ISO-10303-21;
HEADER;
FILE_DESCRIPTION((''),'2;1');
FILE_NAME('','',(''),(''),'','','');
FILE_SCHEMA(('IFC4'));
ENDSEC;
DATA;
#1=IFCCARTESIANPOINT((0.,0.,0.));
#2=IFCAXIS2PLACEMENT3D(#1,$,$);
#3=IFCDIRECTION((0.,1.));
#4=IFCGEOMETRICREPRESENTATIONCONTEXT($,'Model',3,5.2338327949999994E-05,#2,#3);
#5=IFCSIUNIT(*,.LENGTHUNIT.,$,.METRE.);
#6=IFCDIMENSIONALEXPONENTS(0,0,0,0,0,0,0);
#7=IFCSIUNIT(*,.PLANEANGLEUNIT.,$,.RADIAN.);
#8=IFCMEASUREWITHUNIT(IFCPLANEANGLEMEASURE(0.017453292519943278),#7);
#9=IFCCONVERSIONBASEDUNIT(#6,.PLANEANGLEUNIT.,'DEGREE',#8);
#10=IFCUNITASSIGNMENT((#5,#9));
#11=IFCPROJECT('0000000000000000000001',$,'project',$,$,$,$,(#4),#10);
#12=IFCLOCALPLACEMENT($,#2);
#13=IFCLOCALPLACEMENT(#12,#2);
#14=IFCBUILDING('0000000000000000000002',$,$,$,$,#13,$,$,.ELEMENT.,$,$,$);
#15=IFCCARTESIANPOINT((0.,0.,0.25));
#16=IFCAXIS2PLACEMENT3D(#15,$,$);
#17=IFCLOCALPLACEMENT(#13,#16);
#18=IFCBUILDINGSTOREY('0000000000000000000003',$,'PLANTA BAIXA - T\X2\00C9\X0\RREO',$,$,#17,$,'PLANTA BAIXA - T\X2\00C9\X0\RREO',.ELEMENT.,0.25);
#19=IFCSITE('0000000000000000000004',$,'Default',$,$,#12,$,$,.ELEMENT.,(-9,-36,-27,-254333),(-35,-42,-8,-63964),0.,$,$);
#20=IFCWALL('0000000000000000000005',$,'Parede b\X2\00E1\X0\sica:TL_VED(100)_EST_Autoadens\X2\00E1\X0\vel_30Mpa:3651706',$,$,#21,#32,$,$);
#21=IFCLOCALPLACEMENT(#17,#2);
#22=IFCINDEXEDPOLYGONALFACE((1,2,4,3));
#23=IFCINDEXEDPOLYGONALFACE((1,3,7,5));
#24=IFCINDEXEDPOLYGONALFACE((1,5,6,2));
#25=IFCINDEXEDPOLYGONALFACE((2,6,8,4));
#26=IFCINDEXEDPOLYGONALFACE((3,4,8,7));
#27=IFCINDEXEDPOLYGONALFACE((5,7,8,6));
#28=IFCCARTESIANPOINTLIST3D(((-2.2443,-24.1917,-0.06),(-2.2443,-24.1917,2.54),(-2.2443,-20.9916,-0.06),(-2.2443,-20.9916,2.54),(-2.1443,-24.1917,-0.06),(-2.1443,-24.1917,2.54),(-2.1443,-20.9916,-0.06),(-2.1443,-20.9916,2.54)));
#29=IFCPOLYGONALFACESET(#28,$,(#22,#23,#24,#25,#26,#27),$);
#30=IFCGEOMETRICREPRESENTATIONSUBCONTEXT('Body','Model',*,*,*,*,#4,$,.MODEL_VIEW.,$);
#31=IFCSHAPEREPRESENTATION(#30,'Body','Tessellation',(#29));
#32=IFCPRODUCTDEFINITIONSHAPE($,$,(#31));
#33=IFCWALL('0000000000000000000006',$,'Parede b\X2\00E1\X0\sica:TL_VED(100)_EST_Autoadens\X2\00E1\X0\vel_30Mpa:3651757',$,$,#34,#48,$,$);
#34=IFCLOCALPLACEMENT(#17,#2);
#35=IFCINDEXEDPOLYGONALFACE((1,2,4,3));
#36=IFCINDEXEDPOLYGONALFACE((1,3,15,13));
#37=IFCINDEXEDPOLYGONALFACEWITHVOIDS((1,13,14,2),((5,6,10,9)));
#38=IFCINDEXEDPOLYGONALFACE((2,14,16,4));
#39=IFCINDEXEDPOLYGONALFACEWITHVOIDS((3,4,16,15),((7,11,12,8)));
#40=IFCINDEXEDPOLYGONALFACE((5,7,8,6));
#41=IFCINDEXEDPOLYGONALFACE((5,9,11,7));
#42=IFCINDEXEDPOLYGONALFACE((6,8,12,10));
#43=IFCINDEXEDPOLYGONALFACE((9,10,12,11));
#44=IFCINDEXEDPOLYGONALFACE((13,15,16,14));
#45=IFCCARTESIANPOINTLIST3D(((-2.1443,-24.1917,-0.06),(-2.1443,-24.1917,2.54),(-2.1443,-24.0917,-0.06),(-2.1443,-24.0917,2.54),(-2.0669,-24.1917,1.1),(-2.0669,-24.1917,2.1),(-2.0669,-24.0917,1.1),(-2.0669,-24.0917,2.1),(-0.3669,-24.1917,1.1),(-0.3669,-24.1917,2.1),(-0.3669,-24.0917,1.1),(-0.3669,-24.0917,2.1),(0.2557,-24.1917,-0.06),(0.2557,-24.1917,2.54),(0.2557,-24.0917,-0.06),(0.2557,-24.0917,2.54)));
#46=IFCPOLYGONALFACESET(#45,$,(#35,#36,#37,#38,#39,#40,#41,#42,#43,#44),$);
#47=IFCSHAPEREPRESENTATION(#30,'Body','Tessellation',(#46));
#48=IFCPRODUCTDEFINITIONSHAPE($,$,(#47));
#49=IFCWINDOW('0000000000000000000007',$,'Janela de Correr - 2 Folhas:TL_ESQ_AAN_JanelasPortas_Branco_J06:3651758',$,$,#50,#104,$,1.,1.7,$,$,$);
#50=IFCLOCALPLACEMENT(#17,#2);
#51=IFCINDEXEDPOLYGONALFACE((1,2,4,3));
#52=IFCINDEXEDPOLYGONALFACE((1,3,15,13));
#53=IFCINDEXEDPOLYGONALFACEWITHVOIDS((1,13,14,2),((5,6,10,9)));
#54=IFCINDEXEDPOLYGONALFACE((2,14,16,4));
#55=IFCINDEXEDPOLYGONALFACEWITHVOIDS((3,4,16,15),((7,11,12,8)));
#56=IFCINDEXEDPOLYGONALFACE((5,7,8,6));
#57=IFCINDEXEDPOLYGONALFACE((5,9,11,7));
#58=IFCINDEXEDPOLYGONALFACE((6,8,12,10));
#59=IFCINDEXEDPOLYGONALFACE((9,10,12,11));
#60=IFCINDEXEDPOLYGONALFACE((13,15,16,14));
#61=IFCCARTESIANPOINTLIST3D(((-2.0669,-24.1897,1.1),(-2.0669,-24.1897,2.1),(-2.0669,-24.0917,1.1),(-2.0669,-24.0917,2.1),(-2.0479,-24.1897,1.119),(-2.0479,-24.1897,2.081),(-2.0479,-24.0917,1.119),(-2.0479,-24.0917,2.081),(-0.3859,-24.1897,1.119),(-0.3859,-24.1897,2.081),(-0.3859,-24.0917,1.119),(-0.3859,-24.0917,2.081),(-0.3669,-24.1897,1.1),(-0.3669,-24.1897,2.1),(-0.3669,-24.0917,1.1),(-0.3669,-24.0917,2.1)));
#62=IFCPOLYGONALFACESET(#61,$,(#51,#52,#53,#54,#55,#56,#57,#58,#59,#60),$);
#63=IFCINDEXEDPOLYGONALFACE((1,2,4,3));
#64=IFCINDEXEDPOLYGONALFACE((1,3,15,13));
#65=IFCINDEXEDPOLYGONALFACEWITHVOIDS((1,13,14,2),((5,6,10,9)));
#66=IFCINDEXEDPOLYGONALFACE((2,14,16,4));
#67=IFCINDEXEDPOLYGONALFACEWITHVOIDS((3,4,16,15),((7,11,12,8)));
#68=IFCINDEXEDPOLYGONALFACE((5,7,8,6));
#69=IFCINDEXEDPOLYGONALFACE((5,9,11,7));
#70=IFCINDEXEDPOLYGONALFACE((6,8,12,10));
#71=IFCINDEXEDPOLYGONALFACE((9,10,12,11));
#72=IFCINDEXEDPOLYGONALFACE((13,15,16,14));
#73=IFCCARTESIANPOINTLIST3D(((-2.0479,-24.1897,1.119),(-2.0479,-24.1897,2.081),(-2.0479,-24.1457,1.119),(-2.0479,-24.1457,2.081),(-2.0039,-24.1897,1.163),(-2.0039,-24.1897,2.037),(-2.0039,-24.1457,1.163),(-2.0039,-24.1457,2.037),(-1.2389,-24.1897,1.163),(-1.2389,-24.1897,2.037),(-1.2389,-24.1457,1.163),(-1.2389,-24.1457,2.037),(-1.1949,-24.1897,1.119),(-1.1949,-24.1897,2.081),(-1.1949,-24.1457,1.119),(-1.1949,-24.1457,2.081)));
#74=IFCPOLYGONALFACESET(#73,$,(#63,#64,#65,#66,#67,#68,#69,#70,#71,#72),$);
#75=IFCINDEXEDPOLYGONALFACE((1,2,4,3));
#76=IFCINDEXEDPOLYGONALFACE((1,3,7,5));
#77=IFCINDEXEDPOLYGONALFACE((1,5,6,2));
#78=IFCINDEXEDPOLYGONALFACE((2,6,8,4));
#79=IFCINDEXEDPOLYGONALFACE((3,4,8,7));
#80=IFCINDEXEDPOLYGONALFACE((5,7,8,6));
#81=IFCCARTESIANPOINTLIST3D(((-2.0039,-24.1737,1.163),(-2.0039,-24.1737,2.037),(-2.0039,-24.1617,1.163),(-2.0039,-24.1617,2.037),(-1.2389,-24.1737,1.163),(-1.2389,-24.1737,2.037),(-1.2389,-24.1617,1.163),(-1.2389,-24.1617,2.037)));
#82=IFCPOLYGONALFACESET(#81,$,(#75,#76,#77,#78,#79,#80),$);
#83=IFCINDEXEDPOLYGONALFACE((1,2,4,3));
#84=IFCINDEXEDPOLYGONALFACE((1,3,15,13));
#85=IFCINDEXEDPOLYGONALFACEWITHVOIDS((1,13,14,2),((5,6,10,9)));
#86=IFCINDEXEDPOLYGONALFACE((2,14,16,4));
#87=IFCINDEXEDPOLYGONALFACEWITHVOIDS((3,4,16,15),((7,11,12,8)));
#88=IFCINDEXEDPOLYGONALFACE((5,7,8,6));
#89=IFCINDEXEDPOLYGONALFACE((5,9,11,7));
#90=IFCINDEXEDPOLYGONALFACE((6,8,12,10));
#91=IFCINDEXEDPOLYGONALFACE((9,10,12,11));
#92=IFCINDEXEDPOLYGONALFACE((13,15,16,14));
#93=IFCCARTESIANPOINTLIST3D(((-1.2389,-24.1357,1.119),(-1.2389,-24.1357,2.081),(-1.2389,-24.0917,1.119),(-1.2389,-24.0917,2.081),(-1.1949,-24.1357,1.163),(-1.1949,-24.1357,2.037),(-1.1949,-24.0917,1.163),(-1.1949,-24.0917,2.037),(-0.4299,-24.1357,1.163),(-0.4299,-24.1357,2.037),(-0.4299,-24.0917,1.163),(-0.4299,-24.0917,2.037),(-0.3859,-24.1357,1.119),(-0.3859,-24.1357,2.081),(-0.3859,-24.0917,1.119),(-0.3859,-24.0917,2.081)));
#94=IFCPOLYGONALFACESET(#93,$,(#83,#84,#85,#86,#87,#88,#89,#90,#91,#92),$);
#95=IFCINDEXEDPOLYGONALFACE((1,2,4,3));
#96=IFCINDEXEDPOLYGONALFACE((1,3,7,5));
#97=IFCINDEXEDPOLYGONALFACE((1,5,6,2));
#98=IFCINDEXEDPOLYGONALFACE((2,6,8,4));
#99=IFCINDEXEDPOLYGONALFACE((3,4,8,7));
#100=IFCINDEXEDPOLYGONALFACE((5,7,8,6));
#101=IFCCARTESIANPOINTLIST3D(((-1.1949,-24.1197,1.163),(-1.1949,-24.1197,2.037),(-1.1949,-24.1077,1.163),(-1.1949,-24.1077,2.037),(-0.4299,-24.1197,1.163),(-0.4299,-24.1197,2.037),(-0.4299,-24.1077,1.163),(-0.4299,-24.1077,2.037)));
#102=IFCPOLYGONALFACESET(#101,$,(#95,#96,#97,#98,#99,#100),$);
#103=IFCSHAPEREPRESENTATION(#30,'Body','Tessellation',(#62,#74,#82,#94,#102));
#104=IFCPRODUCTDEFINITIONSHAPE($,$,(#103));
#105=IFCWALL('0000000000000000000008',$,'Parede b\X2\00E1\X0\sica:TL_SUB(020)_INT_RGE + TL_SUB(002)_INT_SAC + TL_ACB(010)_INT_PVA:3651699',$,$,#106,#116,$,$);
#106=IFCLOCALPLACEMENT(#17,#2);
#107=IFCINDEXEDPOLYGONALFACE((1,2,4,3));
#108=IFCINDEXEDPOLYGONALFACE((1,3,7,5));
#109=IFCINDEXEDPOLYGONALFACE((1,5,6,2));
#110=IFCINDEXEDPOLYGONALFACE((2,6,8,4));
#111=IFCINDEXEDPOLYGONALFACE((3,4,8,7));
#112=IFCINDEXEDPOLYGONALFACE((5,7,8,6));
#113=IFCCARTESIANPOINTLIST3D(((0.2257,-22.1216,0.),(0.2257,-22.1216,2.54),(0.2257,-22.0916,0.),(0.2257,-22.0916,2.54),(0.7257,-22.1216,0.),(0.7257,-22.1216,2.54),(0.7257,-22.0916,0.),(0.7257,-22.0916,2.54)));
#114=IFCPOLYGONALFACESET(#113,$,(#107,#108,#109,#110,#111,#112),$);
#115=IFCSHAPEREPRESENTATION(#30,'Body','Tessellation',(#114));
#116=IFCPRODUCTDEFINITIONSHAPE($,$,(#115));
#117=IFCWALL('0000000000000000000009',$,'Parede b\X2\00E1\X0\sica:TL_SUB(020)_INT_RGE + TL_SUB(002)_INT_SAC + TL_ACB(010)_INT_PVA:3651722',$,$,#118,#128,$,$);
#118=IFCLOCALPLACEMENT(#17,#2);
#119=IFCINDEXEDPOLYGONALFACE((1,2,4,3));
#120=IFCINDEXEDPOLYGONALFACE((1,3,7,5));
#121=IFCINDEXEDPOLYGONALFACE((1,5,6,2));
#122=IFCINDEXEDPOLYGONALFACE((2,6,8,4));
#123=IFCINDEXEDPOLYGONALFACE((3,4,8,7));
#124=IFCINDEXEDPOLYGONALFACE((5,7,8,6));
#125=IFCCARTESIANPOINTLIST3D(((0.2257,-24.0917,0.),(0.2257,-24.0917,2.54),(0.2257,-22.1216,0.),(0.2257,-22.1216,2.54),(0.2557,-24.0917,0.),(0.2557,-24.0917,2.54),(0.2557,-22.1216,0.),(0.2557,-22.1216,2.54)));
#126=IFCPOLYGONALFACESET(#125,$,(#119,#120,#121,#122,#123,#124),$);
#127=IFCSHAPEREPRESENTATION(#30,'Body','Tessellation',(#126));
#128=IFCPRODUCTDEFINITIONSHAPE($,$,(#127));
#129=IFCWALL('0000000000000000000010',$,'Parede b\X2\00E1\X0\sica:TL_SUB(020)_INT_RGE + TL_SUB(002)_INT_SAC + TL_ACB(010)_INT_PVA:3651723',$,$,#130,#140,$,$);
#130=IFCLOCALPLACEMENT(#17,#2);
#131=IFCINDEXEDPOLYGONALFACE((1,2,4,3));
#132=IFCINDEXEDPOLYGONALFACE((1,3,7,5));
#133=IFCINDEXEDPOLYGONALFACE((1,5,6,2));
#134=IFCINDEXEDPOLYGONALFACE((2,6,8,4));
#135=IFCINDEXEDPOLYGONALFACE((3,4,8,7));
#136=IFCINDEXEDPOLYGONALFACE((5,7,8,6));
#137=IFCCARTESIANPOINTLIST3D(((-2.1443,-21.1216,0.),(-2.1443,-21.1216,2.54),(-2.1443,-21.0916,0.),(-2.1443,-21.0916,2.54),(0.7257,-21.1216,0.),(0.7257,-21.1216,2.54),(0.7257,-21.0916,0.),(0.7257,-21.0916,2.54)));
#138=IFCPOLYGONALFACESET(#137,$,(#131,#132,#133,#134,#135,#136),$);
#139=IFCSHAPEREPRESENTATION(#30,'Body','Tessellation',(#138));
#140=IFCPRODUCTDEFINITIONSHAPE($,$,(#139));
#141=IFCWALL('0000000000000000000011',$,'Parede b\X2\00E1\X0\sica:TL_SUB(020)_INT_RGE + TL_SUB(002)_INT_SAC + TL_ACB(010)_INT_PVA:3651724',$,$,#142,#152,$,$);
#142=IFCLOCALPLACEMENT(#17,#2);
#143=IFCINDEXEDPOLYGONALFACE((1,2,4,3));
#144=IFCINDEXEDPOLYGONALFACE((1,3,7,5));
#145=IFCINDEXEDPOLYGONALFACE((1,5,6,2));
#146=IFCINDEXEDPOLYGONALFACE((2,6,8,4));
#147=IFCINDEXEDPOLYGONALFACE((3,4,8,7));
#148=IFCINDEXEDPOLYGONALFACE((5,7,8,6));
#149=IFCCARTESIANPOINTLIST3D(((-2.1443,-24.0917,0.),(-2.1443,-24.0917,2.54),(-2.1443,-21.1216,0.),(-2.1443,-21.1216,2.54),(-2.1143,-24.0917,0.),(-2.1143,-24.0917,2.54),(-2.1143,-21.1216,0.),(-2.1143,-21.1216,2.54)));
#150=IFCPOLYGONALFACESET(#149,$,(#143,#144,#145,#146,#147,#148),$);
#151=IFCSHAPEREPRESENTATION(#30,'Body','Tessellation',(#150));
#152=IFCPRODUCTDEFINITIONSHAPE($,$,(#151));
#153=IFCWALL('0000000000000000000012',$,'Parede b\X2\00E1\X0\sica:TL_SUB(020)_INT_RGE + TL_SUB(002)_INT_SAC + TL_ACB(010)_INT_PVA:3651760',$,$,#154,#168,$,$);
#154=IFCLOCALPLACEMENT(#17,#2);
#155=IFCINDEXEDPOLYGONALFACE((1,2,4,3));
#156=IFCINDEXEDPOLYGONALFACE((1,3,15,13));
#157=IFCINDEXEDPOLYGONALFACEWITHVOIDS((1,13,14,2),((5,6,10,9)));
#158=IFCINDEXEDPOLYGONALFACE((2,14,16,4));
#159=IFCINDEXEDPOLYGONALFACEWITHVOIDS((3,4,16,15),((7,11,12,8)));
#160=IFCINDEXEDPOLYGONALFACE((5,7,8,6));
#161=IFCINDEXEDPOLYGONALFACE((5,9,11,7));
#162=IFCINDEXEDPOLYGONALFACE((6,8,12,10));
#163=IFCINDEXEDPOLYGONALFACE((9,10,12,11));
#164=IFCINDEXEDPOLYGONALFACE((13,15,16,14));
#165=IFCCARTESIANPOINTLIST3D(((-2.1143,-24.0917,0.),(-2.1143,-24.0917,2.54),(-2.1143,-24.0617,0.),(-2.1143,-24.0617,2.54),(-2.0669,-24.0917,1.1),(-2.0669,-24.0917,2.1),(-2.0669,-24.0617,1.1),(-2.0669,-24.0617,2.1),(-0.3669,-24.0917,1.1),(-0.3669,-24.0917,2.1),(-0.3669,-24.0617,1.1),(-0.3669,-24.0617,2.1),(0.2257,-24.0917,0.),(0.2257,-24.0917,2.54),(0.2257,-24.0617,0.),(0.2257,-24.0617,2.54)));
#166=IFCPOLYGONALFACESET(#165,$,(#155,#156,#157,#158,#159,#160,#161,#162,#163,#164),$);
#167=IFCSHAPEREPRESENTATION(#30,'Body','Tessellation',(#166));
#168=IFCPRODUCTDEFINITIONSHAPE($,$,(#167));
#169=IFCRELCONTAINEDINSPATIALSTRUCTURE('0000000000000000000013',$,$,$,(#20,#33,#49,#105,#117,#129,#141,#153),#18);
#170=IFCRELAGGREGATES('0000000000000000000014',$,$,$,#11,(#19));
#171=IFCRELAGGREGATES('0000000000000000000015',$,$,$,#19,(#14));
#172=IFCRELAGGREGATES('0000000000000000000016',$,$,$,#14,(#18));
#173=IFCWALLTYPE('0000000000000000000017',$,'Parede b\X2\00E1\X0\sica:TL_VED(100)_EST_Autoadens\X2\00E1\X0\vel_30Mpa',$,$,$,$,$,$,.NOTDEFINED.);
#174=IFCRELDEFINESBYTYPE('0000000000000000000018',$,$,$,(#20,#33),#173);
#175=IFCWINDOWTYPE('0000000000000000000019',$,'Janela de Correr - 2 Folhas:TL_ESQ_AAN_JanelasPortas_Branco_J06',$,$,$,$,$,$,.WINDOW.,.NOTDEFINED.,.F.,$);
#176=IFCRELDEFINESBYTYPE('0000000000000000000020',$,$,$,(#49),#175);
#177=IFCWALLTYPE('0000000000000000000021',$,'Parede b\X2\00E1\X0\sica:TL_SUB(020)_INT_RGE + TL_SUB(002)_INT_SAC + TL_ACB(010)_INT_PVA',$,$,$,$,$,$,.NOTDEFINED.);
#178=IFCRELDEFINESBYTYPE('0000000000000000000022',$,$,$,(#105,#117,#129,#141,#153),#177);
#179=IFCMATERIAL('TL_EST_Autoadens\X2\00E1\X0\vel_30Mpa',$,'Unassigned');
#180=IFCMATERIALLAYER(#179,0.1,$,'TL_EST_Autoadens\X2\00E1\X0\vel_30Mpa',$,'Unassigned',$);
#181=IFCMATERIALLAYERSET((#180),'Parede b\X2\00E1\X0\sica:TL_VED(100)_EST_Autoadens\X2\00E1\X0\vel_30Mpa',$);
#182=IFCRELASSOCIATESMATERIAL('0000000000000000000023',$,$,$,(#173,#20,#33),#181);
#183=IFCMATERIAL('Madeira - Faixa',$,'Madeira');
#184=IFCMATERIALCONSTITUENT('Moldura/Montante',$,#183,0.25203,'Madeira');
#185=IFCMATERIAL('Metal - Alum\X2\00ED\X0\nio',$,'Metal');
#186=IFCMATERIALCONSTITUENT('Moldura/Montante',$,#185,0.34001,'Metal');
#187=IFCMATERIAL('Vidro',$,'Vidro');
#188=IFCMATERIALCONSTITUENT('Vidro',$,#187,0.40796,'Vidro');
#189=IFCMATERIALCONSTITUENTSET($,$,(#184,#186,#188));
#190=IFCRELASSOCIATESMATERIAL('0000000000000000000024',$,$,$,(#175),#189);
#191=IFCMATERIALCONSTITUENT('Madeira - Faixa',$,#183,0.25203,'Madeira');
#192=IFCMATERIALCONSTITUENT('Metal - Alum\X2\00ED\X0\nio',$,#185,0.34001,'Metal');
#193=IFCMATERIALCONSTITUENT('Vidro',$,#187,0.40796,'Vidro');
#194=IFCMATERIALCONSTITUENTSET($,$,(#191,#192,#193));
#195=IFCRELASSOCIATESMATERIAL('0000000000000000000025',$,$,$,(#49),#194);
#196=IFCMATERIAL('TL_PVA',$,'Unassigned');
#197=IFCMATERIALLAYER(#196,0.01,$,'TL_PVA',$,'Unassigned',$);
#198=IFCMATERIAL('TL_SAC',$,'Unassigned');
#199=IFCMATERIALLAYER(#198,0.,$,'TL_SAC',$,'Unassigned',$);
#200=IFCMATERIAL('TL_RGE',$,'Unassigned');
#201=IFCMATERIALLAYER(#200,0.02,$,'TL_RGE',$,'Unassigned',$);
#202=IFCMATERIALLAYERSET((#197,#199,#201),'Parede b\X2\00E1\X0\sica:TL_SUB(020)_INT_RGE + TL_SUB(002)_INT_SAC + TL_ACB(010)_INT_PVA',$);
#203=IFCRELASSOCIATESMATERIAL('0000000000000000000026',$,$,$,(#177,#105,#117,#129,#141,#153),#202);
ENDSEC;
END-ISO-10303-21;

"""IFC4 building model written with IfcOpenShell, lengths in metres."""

from ifc_helpers import new_model, entity, si_unit, converted_unit, direction, frame, frame_2d, origin, origin_2d_with_axis, place, context, subcontext, project, spatial, polyline, rectangle, outline, extrude, source, transform, mapped, material, layer, layer_set, layer_usage, constituent, constituent_set, type_object, type_shapes, element, fill, save


model = new_model("IFC4")

# Units and contexts
model_context = context("Model", 3, precision=5.2338327949999994e-05, world=origin(), true_north=direction((0.0, 1.0)))
body_context = subcontext(model_context, "Body", "Model", "MODEL_VIEW")
ifc_project = project(units=[si_unit("LENGTHUNIT", "METRE"), converted_unit("PLANEANGLEUNIT", "DEGREE", entity("IfcPlaneAngleMeasure", 0.017453292519943278), si_unit("PLANEANGLEUNIT", "RADIAN"), dimensions=[0, 0, 0, 0, 0, 0, 0])], contexts=[model_context])

# Site, building, storey
site_placement = place(None, frame((0.0, 0.0, 0.0)))
site = spatial("IfcSite", under=ifc_project, at=site_placement, Name="Default", CompositionType="ELEMENT", RefLatitude=(-9, -36, -27, -254333), RefLongitude=(-35, -42, -8, -63964), RefElevation=0.0)
building_placement = place(site_placement, origin())
building = spatial("IfcBuilding", under=site, at=building_placement, CompositionType="ELEMENT")
storey_placement = place(building_placement, frame((0.0, 0.0, 0.25)))
storey = spatial("IfcBuildingStorey", under=building, at=storey_placement, Name="PLANTA BAIXA - TÉRREO", LongName="PLANTA BAIXA - TÉRREO", CompositionType="ELEMENT", Elevation=0.25)

# Wall
ifc_material_1 = material(Name="TL_EST_Autoadensável_30Mpa", Category="Unassigned")
ifc_layer_1 = layer(ifc_material_1, 0.1, Name="TL_EST_Autoadensável_30Mpa", Category="Unassigned")
ifc_layer_set_1 = layer_set([ifc_layer_1], Name="Parede básica:TL_VED(100)_EST_Autoadensável_30Mpa")
ifc_layer_usage_1 = layer_usage(ifc_layer_set_1, "AXIS2", "POSITIVE", -0.05)
wall_type_1 = type_object("IfcWallType", Name="Parede básica:TL_VED(100)_EST_Autoadensável_30Mpa", PredefinedType="NOTDEFINED", material=ifc_layer_set_1)
wall_1_placement = place(storey_placement, frame((-2.1943, -24.1917, -0.06), z_axis=(0.0, 0.0, 1.0), x_axis=(0.0, 1.0, 0.0)))
element("IfcWall", 1, at=wall_1_placement, inside=storey, type_object=wall_type_1, material=ifc_layer_usage_1, Name="Parede básica:TL_VED(100)_EST_Autoadensável_30Mpa:3651706", context=body_context, shape_type="SweptSolid", body=[
    extrude(rectangle(XDim=3.2001, YDim=0.1, at=frame_2d((1.6001, 0.0), x_axis=(-1.0, 0.0))), origin(), (0.0, 0.0, 1.0), 2.6),
])

# Wall, opening, window
ifc_layer_usage_2 = layer_usage(ifc_layer_set_1, "AXIS2", "POSITIVE", -0.05)
wall_2_placement = place(storey_placement, frame((-2.1443, -24.1417, -0.06)))
wall_2 = element("IfcWall", 2, at=wall_2_placement, inside=storey, type_object=wall_type_1, material=ifc_layer_usage_2, Name="Parede básica:TL_VED(100)_EST_Autoadensável_30Mpa:3651757", context=body_context, shape_type="SweptSolid", body=[
    extrude(rectangle(XDim=2.4, YDim=0.1, at=frame_2d((1.2, 0.0), x_axis=(-1.0, 0.0))), origin(), (0.0, 0.0, 1.0), 2.6),
])
opening_1_placement = place(wall_2_placement, frame((1.7774, 0.05, 1.16)))
opening_1 = element("IfcOpeningElement", 3, at=opening_1_placement, cuts=wall_2, PredefinedType="OPENING", context=body_context, shape_type="SweptSolid", body=[
    extrude(rectangle(XDim=1.0, YDim=1.7, at=frame_2d((0.5, 0.85), x_axis=(-1.0, 0.0))), frame((0.0, 0.0, 0.0), z_axis=(0.0, -1.0, 0.0), x_axis=(0.0, 0.0, 1.0)), (0.0, 0.0, 1.0), 0.1),
])
ifc_material_2 = material(Name="Madeira - Faixa", Category="Madeira")
ifc_constituent_1 = constituent(ifc_material_2, Name="Madeira - Faixa", Category="Madeira", fraction=0.25203)
ifc_material_3 = material(Name="Metal - Alumínio", Category="Metal")
ifc_constituent_2 = constituent(ifc_material_3, Name="Metal - Alumínio", Category="Metal", fraction=0.34001)
ifc_material_4 = material(Name="Vidro", Category="Vidro")
ifc_constituent_3 = constituent(ifc_material_4, Name="Vidro", Category="Vidro", fraction=0.40796)
ifc_constituent_set_1 = constituent_set(constituents=[ifc_constituent_1, ifc_constituent_2, ifc_constituent_3])
ifc_constituent_4 = constituent(ifc_material_2, Name="Moldura/Montante", Category="Madeira", fraction=0.25203)
ifc_constituent_5 = constituent(ifc_material_3, Name="Moldura/Montante", Category="Metal", fraction=0.34001)
ifc_constituent_6 = constituent(ifc_material_4, Name="Vidro", Category="Vidro", fraction=0.40796)
ifc_constituent_set_2 = constituent_set(constituents=[ifc_constituent_4, ifc_constituent_5, ifc_constituent_6])
window_type = type_object("IfcWindowType", Name="Janela de Correr - 2 Folhas:TL_ESQ_AAN_JanelasPortas_Branco_J06", ParameterTakesPrecedence=False, PartitioningType="NOTDEFINED", PredefinedType="WINDOW", material=ifc_constituent_set_2)
shared_shape_1 = source(origin(), body_context, "Body", "SweptSolid", [
    extrude(outline(polyline([(-0.85, -0.5), (0.85, -0.5), (0.85, 0.5), (-0.85, 0.5), (-0.85, -0.5)]), holes=[polyline([(-0.831, -0.481), (-0.831, 0.481), (0.831, 0.481), (0.831, -0.481), (-0.831, -0.481)])]), frame((0.85, 0.0, 0.5), z_axis=(0.0, 1.0, 0.0), x_axis=(1.0, 0.0, 0.0)), (0.0, 0.0, 1.0), 0.098),
    extrude(outline(polyline([(-0.4265, -0.481), (0.4265, -0.481), (0.4265, 0.481), (-0.4265, 0.481), (-0.4265, -0.481)]), holes=[polyline([(-0.3825, -0.437), (-0.3825, 0.437), (0.3825, 0.437), (0.3825, -0.437), (-0.3825, -0.437)])]), frame((1.2545, 0.054, 0.5), z_axis=(0.0, 1.0, 0.0), x_axis=(1.0, 0.0, 0.0)), (0.0, 0.0, 1.0), 0.044),
    extrude(rectangle(XDim=0.012, YDim=0.765, at=origin_2d_with_axis()), frame((1.2545, 0.076, 0.063), z_axis=(0.0, 0.0, 1.0), x_axis=(0.0, -1.0, 0.0)), (0.0, 0.0, 1.0), 0.874),
    extrude(outline(polyline([(-0.481, -0.4265), (0.481, -0.4265), (0.481, 0.4265), (-0.481, 0.4265), (-0.481, -0.4265)]), holes=[polyline([(-0.437, -0.3825), (-0.437, 0.3825), (0.437, 0.3825), (0.437, -0.3825), (-0.437, -0.3825)])]), frame((0.4455, 0.0, 0.5), z_axis=(0.0, 1.0, 0.0), x_axis=(0.0, 0.0, -1.0)), (0.0, 0.0, 1.0), 0.044),
    extrude(rectangle(XDim=0.012, YDim=0.765, at=origin_2d_with_axis()), frame((0.4455, 0.022, 0.063), z_axis=(0.0, 0.0, 1.0), x_axis=(0.0, -1.0, 0.0)), (0.0, 0.0, 1.0), 0.874),
])
type_shapes(window_type, [shared_shape_1])
window_placement = place(opening_1_placement, frame((0.0, 0.0, 0.0), z_axis=(0.0, 0.0, 1.0), x_axis=(-1.0, 0.0, 0.0)))
window = element("IfcWindow", 4, at=window_placement, inside=storey, type_object=window_type, material=ifc_constituent_set_1, Name="Janela de Correr - 2 Folhas:TL_ESQ_AAN_JanelasPortas_Branco_J06:3651758", OverallHeight=1.0, OverallWidth=1.7, context=body_context, shape_type="MappedRepresentation", body=[
    mapped(shared_shape_1, transform((0.0, 0.0, 0.0), scale=1.0)),
])
fill(opening_1, window)

# Walls
ifc_material_5 = material(Name="TL_PVA", Category="Unassigned")
ifc_layer_2 = layer(ifc_material_5, 0.01, Name="TL_PVA", Category="Unassigned")
ifc_material_6 = material(Name="TL_SAC", Category="Unassigned")
ifc_layer_3 = layer(ifc_material_6, 0.0, Name="TL_SAC", Category="Unassigned")
ifc_material_7 = material(Name="TL_RGE", Category="Unassigned")
ifc_layer_4 = layer(ifc_material_7, 0.02, Name="TL_RGE", Category="Unassigned")
ifc_layer_set_2 = layer_set([ifc_layer_2, ifc_layer_3, ifc_layer_4], Name="Parede básica:TL_SUB(020)_INT_RGE + TL_SUB(002)_INT_SAC + TL_ACB(010)_INT_PVA")
ifc_layer_usage_3 = layer_usage(ifc_layer_set_2, "AXIS2", "NEGATIVE", 0.015)
wall_type_2 = type_object("IfcWallType", Name="Parede básica:TL_SUB(020)_INT_RGE + TL_SUB(002)_INT_SAC + TL_ACB(010)_INT_PVA", PredefinedType="NOTDEFINED", material=ifc_layer_set_2)
wall_3_placement = place(storey_placement, frame((0.2257, -22.1066, 0.0)))
element("IfcWall", 5, at=wall_3_placement, inside=storey, type_object=wall_type_2, material=ifc_layer_usage_3, Name="Parede básica:TL_SUB(020)_INT_RGE + TL_SUB(002)_INT_SAC + TL_ACB(010)_INT_PVA:3651699", context=body_context, shape_type="SweptSolid", body=[
    extrude(rectangle(XDim=0.5, YDim=0.03, at=frame_2d((0.25, 0.0), x_axis=(-1.0, 0.0))), origin(), (0.0, 0.0, 1.0), 2.54),
])
ifc_layer_usage_4 = layer_usage(ifc_layer_set_2, "AXIS2", "POSITIVE", -0.015)
wall_4_placement = place(storey_placement, frame((0.2407, -22.1216, 0.0), z_axis=(0.0, 0.0, 1.0), x_axis=(0.0, -1.0, 0.0)))
element("IfcWall", 6, at=wall_4_placement, inside=storey, type_object=wall_type_2, material=ifc_layer_usage_4, Name="Parede básica:TL_SUB(020)_INT_RGE + TL_SUB(002)_INT_SAC + TL_ACB(010)_INT_PVA:3651722", context=body_context, shape_type="SweptSolid", body=[
    extrude(rectangle(XDim=1.9701, YDim=0.03, at=frame_2d((0.9851, 0.0), x_axis=(-1.0, 0.0))), origin(), (0.0, 0.0, 1.0), 2.54),
])
ifc_layer_usage_5 = layer_usage(ifc_layer_set_2, "AXIS2", "POSITIVE", -0.015)
wall_5_placement = place(storey_placement, frame((-2.1443, -21.1066, 0.0)))
element("IfcWall", 7, at=wall_5_placement, inside=storey, type_object=wall_type_2, material=ifc_layer_usage_5, Name="Parede básica:TL_SUB(020)_INT_RGE + TL_SUB(002)_INT_SAC + TL_ACB(010)_INT_PVA:3651723", context=body_context, shape_type="SweptSolid", body=[
    extrude(rectangle(XDim=2.87, YDim=0.03, at=frame_2d((1.435, 0.0), x_axis=(-1.0, 0.0))), origin(), (0.0, 0.0, 1.0), 2.54),
])
ifc_layer_usage_6 = layer_usage(ifc_layer_set_2, "AXIS2", "POSITIVE", -0.015)
wall_6_placement = place(storey_placement, frame((-2.1293, -24.0917, 0.0), z_axis=(0.0, 0.0, 1.0), x_axis=(0.0, 1.0, 0.0)))
element("IfcWall", 8, at=wall_6_placement, inside=storey, type_object=wall_type_2, material=ifc_layer_usage_6, Name="Parede básica:TL_SUB(020)_INT_RGE + TL_SUB(002)_INT_SAC + TL_ACB(010)_INT_PVA:3651724", context=body_context, shape_type="SweptSolid", body=[
    extrude(rectangle(XDim=2.9701, YDim=0.03, at=frame_2d((1.4851, 0.0), x_axis=(-1.0, 0.0))), origin(), (0.0, 0.0, 1.0), 2.54),
])

# Wall, opening
ifc_layer_usage_7 = layer_usage(ifc_layer_set_2, "AXIS2", "POSITIVE", -0.015)
wall_7_placement = place(storey_placement, frame((0.2257, -24.0767, 0.0), z_axis=(0.0, 0.0, 1.0), x_axis=(-1.0, 0.0, 0.0)))
wall_7 = element("IfcWall", 9, at=wall_7_placement, inside=storey, type_object=wall_type_2, material=ifc_layer_usage_7, Name="Parede básica:TL_SUB(020)_INT_RGE + TL_SUB(002)_INT_SAC + TL_ACB(010)_INT_PVA:3651760", context=body_context, shape_type="SweptSolid", body=[
    extrude(rectangle(XDim=2.34, YDim=0.03, at=frame_2d((1.17, 0.0), x_axis=(-1.0, 0.0))), origin(), (0.0, 0.0, 1.0), 2.54),
])
opening_2_placement = place(wall_7_placement, frame((0.2257, -24.0767, 1.1)))
element("IfcOpeningElement", 10, at=opening_2_placement, cuts=wall_7, PredefinedType="OPENING", context=body_context, shape_type="SweptSolid", body=[
    extrude(rectangle(XDim=1.0, YDim=1.7, at=frame_2d((0.0, 0.0), x_axis=(0.0, 1.0))), frame((1.2169, 22.5677, 0.5), z_axis=(0.0, 1.0, 0.0), x_axis=(1.0, 0.0, 0.0)), (0.0, 0.0, 1.0), 3.048),
])

save(model, "model.ifc")
